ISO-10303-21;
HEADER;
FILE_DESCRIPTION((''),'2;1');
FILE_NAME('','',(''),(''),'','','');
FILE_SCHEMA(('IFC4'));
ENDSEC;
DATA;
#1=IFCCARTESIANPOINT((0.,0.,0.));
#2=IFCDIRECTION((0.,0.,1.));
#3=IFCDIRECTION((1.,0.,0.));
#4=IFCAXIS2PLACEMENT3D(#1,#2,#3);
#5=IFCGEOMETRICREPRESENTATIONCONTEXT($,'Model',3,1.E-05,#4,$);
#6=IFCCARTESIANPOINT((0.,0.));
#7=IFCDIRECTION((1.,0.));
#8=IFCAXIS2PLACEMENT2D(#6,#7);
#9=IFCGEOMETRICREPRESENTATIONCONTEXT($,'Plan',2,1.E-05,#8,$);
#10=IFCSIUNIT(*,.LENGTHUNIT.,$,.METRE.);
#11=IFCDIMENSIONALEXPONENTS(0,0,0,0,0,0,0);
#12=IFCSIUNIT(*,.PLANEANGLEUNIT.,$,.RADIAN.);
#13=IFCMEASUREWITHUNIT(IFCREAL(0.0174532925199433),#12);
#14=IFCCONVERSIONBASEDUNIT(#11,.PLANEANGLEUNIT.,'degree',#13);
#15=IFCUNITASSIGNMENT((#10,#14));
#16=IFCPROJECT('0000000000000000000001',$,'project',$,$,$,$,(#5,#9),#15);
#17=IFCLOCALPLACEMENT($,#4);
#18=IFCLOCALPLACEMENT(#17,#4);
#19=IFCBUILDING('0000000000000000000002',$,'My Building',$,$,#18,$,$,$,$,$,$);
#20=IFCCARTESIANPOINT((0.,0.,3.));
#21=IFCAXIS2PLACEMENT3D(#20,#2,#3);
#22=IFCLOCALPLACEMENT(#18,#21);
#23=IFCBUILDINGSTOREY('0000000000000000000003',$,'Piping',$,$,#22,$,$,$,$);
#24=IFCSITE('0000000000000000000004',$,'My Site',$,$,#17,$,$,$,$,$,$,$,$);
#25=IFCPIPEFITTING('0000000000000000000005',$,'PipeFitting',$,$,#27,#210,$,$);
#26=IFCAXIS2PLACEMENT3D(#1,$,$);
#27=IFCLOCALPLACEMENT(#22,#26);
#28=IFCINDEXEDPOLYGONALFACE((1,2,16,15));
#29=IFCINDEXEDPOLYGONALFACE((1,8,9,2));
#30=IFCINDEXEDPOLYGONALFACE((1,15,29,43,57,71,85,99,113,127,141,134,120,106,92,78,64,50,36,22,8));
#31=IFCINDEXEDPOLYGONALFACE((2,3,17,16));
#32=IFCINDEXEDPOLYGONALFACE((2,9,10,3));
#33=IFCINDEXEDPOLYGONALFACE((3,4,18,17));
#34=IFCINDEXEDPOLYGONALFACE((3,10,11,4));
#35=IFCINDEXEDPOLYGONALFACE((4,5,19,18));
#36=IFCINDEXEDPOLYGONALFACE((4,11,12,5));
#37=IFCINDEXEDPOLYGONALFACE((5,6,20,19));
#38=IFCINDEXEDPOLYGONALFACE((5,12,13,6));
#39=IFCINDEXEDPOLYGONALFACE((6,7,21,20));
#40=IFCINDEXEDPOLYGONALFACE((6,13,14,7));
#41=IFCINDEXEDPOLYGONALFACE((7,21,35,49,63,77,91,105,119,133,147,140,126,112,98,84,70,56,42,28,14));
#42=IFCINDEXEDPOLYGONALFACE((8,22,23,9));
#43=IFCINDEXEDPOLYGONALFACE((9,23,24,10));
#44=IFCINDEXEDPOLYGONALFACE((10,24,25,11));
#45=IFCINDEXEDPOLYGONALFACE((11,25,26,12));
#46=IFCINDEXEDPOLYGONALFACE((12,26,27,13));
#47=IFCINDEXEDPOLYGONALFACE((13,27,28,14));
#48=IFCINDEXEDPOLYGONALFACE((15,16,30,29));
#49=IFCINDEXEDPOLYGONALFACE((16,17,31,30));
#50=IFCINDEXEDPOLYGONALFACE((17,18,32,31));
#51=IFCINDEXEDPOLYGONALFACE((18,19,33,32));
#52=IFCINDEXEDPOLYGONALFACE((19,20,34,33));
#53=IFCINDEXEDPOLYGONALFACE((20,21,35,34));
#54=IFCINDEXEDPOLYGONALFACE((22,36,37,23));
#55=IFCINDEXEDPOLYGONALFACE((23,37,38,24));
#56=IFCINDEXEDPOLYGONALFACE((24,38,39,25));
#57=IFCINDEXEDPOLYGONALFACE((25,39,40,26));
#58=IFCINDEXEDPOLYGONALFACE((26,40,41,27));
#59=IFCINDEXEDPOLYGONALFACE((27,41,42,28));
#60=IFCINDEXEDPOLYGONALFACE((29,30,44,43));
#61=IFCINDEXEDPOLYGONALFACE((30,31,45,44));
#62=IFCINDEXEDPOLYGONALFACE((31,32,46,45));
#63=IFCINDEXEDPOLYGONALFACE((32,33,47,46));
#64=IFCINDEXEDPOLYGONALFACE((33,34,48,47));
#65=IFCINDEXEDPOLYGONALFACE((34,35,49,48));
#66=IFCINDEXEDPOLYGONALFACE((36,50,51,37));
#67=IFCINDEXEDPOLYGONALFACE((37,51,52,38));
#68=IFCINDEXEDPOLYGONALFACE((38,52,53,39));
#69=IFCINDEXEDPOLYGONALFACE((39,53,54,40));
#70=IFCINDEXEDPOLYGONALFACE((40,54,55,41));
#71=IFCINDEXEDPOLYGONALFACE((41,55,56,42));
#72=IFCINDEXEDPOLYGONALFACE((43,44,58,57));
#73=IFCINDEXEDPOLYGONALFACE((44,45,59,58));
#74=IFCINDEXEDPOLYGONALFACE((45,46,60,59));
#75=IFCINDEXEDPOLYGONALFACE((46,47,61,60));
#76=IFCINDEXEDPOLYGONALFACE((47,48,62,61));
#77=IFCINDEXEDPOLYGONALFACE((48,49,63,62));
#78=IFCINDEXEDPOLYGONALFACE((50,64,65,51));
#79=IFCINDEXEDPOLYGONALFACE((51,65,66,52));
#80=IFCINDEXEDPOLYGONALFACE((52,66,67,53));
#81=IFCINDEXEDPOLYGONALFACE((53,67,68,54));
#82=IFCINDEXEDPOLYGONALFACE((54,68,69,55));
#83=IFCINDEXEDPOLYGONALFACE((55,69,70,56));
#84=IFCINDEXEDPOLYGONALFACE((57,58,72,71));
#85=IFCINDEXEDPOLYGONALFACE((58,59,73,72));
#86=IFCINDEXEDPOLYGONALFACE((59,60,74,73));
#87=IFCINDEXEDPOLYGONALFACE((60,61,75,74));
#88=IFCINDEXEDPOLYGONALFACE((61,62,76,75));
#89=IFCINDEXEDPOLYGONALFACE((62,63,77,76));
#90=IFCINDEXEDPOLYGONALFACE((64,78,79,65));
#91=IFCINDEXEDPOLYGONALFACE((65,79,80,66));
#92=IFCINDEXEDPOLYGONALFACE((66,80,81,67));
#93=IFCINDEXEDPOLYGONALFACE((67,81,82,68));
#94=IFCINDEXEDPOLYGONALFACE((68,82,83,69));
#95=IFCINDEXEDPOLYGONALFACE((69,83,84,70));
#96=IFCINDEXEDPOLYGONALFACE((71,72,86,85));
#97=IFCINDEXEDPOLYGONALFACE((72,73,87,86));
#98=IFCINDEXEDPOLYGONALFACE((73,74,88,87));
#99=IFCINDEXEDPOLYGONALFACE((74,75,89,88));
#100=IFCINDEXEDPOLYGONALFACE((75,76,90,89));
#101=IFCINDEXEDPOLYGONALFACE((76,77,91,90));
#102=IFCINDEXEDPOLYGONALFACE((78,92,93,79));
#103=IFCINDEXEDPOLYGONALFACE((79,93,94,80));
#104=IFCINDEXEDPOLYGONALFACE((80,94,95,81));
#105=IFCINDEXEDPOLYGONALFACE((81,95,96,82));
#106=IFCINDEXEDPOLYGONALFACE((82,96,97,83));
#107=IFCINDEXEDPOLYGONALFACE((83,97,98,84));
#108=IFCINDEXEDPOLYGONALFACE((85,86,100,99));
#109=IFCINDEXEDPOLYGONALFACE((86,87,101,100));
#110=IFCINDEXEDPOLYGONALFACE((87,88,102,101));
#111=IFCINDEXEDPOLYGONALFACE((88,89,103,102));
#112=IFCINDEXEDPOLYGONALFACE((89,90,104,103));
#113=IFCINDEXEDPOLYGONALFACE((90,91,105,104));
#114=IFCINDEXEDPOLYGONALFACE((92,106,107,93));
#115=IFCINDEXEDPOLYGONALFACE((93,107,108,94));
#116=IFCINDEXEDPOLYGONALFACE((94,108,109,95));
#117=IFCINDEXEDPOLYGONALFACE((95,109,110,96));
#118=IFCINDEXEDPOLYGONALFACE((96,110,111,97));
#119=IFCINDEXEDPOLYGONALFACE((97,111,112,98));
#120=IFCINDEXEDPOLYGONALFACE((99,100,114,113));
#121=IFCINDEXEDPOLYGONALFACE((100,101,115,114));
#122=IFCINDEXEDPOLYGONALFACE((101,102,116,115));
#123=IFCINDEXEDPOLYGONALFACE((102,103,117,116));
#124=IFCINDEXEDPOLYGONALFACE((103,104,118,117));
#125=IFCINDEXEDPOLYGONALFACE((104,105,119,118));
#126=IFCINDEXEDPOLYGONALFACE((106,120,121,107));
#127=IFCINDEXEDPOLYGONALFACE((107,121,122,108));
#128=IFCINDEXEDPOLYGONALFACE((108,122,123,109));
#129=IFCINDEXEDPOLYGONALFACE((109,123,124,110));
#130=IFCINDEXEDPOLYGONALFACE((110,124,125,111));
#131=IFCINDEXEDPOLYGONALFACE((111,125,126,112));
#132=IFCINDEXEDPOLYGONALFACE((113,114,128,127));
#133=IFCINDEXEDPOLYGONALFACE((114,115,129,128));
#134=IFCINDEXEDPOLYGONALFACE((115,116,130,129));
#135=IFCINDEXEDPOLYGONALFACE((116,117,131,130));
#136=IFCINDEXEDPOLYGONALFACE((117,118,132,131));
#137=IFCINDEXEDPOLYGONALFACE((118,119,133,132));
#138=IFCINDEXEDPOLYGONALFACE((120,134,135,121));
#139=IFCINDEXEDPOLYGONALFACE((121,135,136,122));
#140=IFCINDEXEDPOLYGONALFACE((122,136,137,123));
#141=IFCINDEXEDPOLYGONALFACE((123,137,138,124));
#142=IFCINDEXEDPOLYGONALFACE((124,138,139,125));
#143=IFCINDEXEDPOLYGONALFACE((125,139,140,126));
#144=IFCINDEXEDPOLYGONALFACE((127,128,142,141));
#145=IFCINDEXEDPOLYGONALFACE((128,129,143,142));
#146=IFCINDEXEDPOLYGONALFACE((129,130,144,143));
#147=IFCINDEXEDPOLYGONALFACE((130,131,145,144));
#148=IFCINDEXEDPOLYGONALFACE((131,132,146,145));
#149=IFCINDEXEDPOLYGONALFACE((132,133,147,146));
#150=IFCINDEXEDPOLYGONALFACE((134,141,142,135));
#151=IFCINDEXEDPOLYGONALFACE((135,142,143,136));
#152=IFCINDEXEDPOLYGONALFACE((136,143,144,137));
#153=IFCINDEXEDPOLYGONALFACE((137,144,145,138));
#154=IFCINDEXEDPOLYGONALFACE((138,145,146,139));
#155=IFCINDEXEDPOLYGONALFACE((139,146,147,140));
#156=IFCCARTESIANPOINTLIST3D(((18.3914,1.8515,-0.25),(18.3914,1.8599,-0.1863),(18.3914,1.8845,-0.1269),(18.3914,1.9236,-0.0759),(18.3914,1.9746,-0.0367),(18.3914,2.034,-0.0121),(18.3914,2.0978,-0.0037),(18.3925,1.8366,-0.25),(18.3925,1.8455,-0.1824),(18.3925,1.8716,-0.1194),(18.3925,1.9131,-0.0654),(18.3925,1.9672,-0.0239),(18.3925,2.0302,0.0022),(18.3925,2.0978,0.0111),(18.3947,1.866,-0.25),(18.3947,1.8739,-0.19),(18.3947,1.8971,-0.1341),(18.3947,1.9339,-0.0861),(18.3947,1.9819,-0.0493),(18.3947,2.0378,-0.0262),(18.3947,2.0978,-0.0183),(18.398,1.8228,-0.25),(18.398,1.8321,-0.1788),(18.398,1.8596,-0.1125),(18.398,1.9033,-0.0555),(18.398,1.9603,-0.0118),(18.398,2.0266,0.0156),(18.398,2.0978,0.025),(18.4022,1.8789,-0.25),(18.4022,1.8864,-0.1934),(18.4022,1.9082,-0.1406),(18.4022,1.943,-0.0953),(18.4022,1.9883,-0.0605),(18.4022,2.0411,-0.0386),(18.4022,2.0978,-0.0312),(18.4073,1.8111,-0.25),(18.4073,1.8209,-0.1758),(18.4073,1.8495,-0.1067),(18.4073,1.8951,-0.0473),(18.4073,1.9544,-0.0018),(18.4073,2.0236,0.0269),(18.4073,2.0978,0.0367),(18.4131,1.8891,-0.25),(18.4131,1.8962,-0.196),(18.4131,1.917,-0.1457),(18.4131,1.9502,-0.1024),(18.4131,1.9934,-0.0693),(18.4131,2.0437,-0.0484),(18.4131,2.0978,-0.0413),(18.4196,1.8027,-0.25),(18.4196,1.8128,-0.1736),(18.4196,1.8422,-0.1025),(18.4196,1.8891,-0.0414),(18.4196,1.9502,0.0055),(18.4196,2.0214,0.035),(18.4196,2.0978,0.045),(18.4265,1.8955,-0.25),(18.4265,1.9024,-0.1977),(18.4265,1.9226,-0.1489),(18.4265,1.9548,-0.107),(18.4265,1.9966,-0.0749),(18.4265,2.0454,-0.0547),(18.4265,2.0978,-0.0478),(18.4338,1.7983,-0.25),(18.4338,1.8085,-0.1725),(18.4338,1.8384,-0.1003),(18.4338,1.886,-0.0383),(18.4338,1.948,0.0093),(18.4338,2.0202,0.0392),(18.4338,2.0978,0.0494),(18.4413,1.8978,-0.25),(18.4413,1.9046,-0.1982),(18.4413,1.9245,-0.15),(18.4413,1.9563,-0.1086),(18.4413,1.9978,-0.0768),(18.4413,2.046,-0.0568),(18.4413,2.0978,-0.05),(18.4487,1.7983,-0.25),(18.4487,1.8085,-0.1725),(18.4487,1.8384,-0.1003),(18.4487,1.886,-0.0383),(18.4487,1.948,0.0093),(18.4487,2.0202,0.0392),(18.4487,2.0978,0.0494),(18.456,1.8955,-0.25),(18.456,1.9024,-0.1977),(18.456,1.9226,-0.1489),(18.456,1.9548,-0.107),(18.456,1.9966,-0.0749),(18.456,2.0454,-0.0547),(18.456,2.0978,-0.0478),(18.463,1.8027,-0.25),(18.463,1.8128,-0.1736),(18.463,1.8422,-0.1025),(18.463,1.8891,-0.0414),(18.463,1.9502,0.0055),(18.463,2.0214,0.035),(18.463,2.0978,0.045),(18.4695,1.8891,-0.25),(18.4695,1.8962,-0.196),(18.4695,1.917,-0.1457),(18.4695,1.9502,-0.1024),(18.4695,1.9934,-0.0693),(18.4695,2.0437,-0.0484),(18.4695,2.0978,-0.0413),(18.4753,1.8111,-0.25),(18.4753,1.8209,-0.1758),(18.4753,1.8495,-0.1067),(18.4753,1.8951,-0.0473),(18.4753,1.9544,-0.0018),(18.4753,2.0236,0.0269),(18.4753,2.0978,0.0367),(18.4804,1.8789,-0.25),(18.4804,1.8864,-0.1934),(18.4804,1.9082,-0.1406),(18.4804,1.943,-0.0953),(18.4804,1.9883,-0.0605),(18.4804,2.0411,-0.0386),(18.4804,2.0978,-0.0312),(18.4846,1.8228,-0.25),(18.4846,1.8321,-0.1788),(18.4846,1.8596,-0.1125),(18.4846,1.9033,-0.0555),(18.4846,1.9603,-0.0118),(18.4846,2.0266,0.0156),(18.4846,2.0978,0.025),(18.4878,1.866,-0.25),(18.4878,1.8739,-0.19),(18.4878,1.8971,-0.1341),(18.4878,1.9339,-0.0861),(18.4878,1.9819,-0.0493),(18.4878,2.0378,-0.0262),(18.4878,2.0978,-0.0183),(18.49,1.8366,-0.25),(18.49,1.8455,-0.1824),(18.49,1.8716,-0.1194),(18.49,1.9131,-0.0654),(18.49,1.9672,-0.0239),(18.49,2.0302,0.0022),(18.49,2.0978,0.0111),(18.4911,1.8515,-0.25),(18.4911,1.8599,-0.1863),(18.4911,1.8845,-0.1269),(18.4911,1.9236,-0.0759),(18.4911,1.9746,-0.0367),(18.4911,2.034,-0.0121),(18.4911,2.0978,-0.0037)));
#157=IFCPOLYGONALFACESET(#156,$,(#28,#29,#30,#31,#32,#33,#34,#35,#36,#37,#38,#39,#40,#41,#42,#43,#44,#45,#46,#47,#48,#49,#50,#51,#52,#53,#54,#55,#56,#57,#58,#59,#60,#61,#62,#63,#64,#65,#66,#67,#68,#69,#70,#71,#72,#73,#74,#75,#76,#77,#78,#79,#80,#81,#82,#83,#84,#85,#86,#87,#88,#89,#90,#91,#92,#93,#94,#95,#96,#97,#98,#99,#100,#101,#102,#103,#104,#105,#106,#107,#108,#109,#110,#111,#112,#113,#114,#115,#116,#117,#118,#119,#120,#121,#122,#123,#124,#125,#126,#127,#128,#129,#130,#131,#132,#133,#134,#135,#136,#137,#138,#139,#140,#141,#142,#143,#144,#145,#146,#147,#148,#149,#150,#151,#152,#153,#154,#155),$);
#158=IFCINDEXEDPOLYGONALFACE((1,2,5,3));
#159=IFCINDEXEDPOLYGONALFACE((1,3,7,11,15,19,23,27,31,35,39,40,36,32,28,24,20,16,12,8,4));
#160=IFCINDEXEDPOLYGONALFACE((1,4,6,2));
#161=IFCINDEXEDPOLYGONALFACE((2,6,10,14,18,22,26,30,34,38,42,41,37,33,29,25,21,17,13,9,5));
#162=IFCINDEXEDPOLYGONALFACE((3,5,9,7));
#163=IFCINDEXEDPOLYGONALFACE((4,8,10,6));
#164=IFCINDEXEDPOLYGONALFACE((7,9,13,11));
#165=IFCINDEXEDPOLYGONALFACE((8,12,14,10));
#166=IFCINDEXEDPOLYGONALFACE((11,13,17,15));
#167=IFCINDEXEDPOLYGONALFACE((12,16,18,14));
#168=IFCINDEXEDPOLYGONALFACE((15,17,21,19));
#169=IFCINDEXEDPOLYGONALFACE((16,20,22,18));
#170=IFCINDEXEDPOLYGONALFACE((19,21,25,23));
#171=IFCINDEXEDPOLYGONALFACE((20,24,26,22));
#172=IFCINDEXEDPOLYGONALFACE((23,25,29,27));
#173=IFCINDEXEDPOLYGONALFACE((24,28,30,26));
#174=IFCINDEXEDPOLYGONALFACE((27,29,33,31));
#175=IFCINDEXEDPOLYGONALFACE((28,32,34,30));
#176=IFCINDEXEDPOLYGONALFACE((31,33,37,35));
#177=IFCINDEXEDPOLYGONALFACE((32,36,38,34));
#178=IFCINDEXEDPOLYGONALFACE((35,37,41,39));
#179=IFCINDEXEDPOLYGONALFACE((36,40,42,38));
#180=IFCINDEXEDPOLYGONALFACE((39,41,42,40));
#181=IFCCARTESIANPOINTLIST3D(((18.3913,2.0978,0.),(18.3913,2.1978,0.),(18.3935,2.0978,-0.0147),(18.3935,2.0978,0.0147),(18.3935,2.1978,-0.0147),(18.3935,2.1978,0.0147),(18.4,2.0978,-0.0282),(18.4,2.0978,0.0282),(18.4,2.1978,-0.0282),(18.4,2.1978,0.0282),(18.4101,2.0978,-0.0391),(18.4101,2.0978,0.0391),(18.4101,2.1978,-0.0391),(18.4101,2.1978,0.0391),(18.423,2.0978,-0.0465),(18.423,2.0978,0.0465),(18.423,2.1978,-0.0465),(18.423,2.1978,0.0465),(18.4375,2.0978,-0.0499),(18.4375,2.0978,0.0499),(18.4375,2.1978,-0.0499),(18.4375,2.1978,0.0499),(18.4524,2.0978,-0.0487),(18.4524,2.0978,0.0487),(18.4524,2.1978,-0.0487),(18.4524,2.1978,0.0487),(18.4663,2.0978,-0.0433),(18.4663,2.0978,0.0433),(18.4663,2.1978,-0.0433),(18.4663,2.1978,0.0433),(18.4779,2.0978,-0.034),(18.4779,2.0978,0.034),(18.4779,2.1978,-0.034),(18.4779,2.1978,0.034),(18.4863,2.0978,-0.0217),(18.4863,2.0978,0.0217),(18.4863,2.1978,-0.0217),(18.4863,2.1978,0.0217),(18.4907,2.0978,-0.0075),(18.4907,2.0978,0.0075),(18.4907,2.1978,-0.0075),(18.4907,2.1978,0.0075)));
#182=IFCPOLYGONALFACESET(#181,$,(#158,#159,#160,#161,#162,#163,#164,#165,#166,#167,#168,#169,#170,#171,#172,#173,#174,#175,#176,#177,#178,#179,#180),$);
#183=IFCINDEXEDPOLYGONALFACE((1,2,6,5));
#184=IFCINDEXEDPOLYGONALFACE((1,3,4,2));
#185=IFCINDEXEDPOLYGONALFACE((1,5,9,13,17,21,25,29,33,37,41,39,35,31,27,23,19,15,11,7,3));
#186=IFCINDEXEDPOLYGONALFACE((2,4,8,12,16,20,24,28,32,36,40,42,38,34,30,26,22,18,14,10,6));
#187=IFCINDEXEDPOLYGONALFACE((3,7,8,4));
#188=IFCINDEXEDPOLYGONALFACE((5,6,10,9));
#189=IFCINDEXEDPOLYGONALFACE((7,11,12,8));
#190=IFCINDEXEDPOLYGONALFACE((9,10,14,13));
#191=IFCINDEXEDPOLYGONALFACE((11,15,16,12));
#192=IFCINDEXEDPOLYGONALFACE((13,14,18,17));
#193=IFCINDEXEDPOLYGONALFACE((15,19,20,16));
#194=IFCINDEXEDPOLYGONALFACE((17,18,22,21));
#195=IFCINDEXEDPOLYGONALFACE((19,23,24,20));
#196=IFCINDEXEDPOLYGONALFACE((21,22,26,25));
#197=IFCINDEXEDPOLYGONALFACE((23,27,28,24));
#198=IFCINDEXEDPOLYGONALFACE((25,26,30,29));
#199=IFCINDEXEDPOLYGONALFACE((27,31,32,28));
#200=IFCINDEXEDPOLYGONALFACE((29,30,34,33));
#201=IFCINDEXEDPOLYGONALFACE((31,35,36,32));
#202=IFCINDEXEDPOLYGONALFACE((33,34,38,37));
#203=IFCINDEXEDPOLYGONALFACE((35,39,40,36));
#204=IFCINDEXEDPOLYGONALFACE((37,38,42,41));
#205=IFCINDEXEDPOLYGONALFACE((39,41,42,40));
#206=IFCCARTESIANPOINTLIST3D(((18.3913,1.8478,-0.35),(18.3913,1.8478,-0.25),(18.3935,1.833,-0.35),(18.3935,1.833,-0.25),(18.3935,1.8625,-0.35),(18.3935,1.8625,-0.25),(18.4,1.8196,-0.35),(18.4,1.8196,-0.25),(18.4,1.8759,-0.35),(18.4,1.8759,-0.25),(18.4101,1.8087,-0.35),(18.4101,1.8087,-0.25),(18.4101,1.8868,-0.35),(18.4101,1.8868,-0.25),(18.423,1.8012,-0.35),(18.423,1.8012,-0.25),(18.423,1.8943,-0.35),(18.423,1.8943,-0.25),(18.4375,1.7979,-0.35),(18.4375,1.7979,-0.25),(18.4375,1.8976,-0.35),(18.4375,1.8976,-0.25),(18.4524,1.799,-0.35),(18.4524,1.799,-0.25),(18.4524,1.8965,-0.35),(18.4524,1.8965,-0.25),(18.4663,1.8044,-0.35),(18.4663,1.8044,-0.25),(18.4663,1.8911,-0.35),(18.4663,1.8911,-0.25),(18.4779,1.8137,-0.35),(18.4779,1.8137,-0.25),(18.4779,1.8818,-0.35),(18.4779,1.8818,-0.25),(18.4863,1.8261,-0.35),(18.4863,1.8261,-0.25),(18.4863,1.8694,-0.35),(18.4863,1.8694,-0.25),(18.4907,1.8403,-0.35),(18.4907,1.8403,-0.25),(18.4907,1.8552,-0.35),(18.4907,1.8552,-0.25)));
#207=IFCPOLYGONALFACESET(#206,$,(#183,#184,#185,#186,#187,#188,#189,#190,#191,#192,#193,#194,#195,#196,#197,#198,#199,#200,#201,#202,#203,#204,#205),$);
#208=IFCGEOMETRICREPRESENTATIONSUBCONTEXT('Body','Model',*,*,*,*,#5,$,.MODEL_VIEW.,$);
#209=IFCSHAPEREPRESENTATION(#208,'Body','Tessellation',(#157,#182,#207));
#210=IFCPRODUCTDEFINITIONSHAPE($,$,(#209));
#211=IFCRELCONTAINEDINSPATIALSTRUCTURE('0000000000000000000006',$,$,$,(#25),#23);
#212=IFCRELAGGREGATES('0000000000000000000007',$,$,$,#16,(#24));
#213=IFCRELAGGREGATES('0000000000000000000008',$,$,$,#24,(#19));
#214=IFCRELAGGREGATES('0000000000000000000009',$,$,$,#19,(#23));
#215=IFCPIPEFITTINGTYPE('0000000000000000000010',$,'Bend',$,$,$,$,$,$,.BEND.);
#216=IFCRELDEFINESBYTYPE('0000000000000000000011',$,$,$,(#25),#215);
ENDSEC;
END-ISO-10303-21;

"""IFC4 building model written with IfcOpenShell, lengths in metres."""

from ifc_helpers import new_model, entity, si_unit, converted_unit, frame, origin_with_axes, origin_2d_with_axis, place, context, subcontext, project, spatial, circle, extrude, source, transform, mapped, type_object, type_shapes, element, save


model = new_model("IFC4")

# Units and contexts
model_context = context("Model", 3, precision=1e-05, world=origin_with_axes())
plan_context = context("Plan", 2, precision=1e-05, world=origin_2d_with_axis())
body_context = subcontext(model_context, "Body", "Model", "MODEL_VIEW")
ifc_project = project(units=[si_unit("LENGTHUNIT", "METRE"), converted_unit("PLANEANGLEUNIT", "degree", entity("IfcReal", 0.0174532925199433), si_unit("PLANEANGLEUNIT", "RADIAN"), dimensions=[0, 0, 0, 0, 0, 0, 0])], contexts=[model_context, plan_context])

# Site, building, storey
site_placement = place(None, origin_with_axes())
site = spatial("IfcSite", under=ifc_project, at=site_placement, Name="My Site")
building_placement = place(site_placement, origin_with_axes())
building = spatial("IfcBuilding", under=site, at=building_placement, Name="My Building")
storey_placement = place(building_placement, frame((0.0, 0.0, 3.0), z_axis=(0.0, 0.0, 1.0), x_axis=(1.0, 0.0, 0.0)))
storey = spatial("IfcBuildingStorey", under=building, at=storey_placement, Name="Piping")

# Pipe fitting
pipe_fitting_type = type_object("IfcPipeFittingType", Name="Bend", PredefinedType="BEND")
shared_shape = source(origin_with_axes(), body_context, "Body", "SolidModel", [
    entity("IfcSweptDiskSolid", entity("IfcIndexedPolyCurve", entity("IfcCartesianPointList3D", [[0.0, 0.0, -0.1], [0.0, -0.0732, -0.2768], [0.0, -0.25, -0.35]]), [entity("IfcArcIndex", [1, 2, 3])]), 0.05),
    extrude(circle(Radius=0.05), origin_with_axes(), (0.0, 0.0, -1.0), 0.1),
    extrude(circle(Radius=0.05), frame((0.0, -0.25, -0.35), z_axis=(0.0, -1.0, 0.0), x_axis=(1.0, 0.0, 0.0)), (0.0, 0.0, 1.0), 0.1),
])
type_shapes(pipe_fitting_type, [shared_shape])
for number, where, z_axis, x_axis, name in (
    (1, (18.4413, 2.1978, 0.0), (0.0, 1.0, 0.0), (-1.0, 0.0, 0.0), "PipeFitting"),
):
    element("IfcPipeFitting", number, at=place(storey_placement, frame(where, z_axis=z_axis, x_axis=x_axis)), inside=storey, type_object=pipe_fitting_type, Name=name, context=body_context, shape_type="MappedRepresentation", body=[
        mapped(shared_shape, transform((0.0, 0.0, 0.0), x_axis=(1.0, 0.0, 0.0), y_axis=(0.0, 1.0, 0.0), z_axis=(0.0, 0.0, 1.0), scale=1.0)),
    ])

save(model, "model.ifc")
